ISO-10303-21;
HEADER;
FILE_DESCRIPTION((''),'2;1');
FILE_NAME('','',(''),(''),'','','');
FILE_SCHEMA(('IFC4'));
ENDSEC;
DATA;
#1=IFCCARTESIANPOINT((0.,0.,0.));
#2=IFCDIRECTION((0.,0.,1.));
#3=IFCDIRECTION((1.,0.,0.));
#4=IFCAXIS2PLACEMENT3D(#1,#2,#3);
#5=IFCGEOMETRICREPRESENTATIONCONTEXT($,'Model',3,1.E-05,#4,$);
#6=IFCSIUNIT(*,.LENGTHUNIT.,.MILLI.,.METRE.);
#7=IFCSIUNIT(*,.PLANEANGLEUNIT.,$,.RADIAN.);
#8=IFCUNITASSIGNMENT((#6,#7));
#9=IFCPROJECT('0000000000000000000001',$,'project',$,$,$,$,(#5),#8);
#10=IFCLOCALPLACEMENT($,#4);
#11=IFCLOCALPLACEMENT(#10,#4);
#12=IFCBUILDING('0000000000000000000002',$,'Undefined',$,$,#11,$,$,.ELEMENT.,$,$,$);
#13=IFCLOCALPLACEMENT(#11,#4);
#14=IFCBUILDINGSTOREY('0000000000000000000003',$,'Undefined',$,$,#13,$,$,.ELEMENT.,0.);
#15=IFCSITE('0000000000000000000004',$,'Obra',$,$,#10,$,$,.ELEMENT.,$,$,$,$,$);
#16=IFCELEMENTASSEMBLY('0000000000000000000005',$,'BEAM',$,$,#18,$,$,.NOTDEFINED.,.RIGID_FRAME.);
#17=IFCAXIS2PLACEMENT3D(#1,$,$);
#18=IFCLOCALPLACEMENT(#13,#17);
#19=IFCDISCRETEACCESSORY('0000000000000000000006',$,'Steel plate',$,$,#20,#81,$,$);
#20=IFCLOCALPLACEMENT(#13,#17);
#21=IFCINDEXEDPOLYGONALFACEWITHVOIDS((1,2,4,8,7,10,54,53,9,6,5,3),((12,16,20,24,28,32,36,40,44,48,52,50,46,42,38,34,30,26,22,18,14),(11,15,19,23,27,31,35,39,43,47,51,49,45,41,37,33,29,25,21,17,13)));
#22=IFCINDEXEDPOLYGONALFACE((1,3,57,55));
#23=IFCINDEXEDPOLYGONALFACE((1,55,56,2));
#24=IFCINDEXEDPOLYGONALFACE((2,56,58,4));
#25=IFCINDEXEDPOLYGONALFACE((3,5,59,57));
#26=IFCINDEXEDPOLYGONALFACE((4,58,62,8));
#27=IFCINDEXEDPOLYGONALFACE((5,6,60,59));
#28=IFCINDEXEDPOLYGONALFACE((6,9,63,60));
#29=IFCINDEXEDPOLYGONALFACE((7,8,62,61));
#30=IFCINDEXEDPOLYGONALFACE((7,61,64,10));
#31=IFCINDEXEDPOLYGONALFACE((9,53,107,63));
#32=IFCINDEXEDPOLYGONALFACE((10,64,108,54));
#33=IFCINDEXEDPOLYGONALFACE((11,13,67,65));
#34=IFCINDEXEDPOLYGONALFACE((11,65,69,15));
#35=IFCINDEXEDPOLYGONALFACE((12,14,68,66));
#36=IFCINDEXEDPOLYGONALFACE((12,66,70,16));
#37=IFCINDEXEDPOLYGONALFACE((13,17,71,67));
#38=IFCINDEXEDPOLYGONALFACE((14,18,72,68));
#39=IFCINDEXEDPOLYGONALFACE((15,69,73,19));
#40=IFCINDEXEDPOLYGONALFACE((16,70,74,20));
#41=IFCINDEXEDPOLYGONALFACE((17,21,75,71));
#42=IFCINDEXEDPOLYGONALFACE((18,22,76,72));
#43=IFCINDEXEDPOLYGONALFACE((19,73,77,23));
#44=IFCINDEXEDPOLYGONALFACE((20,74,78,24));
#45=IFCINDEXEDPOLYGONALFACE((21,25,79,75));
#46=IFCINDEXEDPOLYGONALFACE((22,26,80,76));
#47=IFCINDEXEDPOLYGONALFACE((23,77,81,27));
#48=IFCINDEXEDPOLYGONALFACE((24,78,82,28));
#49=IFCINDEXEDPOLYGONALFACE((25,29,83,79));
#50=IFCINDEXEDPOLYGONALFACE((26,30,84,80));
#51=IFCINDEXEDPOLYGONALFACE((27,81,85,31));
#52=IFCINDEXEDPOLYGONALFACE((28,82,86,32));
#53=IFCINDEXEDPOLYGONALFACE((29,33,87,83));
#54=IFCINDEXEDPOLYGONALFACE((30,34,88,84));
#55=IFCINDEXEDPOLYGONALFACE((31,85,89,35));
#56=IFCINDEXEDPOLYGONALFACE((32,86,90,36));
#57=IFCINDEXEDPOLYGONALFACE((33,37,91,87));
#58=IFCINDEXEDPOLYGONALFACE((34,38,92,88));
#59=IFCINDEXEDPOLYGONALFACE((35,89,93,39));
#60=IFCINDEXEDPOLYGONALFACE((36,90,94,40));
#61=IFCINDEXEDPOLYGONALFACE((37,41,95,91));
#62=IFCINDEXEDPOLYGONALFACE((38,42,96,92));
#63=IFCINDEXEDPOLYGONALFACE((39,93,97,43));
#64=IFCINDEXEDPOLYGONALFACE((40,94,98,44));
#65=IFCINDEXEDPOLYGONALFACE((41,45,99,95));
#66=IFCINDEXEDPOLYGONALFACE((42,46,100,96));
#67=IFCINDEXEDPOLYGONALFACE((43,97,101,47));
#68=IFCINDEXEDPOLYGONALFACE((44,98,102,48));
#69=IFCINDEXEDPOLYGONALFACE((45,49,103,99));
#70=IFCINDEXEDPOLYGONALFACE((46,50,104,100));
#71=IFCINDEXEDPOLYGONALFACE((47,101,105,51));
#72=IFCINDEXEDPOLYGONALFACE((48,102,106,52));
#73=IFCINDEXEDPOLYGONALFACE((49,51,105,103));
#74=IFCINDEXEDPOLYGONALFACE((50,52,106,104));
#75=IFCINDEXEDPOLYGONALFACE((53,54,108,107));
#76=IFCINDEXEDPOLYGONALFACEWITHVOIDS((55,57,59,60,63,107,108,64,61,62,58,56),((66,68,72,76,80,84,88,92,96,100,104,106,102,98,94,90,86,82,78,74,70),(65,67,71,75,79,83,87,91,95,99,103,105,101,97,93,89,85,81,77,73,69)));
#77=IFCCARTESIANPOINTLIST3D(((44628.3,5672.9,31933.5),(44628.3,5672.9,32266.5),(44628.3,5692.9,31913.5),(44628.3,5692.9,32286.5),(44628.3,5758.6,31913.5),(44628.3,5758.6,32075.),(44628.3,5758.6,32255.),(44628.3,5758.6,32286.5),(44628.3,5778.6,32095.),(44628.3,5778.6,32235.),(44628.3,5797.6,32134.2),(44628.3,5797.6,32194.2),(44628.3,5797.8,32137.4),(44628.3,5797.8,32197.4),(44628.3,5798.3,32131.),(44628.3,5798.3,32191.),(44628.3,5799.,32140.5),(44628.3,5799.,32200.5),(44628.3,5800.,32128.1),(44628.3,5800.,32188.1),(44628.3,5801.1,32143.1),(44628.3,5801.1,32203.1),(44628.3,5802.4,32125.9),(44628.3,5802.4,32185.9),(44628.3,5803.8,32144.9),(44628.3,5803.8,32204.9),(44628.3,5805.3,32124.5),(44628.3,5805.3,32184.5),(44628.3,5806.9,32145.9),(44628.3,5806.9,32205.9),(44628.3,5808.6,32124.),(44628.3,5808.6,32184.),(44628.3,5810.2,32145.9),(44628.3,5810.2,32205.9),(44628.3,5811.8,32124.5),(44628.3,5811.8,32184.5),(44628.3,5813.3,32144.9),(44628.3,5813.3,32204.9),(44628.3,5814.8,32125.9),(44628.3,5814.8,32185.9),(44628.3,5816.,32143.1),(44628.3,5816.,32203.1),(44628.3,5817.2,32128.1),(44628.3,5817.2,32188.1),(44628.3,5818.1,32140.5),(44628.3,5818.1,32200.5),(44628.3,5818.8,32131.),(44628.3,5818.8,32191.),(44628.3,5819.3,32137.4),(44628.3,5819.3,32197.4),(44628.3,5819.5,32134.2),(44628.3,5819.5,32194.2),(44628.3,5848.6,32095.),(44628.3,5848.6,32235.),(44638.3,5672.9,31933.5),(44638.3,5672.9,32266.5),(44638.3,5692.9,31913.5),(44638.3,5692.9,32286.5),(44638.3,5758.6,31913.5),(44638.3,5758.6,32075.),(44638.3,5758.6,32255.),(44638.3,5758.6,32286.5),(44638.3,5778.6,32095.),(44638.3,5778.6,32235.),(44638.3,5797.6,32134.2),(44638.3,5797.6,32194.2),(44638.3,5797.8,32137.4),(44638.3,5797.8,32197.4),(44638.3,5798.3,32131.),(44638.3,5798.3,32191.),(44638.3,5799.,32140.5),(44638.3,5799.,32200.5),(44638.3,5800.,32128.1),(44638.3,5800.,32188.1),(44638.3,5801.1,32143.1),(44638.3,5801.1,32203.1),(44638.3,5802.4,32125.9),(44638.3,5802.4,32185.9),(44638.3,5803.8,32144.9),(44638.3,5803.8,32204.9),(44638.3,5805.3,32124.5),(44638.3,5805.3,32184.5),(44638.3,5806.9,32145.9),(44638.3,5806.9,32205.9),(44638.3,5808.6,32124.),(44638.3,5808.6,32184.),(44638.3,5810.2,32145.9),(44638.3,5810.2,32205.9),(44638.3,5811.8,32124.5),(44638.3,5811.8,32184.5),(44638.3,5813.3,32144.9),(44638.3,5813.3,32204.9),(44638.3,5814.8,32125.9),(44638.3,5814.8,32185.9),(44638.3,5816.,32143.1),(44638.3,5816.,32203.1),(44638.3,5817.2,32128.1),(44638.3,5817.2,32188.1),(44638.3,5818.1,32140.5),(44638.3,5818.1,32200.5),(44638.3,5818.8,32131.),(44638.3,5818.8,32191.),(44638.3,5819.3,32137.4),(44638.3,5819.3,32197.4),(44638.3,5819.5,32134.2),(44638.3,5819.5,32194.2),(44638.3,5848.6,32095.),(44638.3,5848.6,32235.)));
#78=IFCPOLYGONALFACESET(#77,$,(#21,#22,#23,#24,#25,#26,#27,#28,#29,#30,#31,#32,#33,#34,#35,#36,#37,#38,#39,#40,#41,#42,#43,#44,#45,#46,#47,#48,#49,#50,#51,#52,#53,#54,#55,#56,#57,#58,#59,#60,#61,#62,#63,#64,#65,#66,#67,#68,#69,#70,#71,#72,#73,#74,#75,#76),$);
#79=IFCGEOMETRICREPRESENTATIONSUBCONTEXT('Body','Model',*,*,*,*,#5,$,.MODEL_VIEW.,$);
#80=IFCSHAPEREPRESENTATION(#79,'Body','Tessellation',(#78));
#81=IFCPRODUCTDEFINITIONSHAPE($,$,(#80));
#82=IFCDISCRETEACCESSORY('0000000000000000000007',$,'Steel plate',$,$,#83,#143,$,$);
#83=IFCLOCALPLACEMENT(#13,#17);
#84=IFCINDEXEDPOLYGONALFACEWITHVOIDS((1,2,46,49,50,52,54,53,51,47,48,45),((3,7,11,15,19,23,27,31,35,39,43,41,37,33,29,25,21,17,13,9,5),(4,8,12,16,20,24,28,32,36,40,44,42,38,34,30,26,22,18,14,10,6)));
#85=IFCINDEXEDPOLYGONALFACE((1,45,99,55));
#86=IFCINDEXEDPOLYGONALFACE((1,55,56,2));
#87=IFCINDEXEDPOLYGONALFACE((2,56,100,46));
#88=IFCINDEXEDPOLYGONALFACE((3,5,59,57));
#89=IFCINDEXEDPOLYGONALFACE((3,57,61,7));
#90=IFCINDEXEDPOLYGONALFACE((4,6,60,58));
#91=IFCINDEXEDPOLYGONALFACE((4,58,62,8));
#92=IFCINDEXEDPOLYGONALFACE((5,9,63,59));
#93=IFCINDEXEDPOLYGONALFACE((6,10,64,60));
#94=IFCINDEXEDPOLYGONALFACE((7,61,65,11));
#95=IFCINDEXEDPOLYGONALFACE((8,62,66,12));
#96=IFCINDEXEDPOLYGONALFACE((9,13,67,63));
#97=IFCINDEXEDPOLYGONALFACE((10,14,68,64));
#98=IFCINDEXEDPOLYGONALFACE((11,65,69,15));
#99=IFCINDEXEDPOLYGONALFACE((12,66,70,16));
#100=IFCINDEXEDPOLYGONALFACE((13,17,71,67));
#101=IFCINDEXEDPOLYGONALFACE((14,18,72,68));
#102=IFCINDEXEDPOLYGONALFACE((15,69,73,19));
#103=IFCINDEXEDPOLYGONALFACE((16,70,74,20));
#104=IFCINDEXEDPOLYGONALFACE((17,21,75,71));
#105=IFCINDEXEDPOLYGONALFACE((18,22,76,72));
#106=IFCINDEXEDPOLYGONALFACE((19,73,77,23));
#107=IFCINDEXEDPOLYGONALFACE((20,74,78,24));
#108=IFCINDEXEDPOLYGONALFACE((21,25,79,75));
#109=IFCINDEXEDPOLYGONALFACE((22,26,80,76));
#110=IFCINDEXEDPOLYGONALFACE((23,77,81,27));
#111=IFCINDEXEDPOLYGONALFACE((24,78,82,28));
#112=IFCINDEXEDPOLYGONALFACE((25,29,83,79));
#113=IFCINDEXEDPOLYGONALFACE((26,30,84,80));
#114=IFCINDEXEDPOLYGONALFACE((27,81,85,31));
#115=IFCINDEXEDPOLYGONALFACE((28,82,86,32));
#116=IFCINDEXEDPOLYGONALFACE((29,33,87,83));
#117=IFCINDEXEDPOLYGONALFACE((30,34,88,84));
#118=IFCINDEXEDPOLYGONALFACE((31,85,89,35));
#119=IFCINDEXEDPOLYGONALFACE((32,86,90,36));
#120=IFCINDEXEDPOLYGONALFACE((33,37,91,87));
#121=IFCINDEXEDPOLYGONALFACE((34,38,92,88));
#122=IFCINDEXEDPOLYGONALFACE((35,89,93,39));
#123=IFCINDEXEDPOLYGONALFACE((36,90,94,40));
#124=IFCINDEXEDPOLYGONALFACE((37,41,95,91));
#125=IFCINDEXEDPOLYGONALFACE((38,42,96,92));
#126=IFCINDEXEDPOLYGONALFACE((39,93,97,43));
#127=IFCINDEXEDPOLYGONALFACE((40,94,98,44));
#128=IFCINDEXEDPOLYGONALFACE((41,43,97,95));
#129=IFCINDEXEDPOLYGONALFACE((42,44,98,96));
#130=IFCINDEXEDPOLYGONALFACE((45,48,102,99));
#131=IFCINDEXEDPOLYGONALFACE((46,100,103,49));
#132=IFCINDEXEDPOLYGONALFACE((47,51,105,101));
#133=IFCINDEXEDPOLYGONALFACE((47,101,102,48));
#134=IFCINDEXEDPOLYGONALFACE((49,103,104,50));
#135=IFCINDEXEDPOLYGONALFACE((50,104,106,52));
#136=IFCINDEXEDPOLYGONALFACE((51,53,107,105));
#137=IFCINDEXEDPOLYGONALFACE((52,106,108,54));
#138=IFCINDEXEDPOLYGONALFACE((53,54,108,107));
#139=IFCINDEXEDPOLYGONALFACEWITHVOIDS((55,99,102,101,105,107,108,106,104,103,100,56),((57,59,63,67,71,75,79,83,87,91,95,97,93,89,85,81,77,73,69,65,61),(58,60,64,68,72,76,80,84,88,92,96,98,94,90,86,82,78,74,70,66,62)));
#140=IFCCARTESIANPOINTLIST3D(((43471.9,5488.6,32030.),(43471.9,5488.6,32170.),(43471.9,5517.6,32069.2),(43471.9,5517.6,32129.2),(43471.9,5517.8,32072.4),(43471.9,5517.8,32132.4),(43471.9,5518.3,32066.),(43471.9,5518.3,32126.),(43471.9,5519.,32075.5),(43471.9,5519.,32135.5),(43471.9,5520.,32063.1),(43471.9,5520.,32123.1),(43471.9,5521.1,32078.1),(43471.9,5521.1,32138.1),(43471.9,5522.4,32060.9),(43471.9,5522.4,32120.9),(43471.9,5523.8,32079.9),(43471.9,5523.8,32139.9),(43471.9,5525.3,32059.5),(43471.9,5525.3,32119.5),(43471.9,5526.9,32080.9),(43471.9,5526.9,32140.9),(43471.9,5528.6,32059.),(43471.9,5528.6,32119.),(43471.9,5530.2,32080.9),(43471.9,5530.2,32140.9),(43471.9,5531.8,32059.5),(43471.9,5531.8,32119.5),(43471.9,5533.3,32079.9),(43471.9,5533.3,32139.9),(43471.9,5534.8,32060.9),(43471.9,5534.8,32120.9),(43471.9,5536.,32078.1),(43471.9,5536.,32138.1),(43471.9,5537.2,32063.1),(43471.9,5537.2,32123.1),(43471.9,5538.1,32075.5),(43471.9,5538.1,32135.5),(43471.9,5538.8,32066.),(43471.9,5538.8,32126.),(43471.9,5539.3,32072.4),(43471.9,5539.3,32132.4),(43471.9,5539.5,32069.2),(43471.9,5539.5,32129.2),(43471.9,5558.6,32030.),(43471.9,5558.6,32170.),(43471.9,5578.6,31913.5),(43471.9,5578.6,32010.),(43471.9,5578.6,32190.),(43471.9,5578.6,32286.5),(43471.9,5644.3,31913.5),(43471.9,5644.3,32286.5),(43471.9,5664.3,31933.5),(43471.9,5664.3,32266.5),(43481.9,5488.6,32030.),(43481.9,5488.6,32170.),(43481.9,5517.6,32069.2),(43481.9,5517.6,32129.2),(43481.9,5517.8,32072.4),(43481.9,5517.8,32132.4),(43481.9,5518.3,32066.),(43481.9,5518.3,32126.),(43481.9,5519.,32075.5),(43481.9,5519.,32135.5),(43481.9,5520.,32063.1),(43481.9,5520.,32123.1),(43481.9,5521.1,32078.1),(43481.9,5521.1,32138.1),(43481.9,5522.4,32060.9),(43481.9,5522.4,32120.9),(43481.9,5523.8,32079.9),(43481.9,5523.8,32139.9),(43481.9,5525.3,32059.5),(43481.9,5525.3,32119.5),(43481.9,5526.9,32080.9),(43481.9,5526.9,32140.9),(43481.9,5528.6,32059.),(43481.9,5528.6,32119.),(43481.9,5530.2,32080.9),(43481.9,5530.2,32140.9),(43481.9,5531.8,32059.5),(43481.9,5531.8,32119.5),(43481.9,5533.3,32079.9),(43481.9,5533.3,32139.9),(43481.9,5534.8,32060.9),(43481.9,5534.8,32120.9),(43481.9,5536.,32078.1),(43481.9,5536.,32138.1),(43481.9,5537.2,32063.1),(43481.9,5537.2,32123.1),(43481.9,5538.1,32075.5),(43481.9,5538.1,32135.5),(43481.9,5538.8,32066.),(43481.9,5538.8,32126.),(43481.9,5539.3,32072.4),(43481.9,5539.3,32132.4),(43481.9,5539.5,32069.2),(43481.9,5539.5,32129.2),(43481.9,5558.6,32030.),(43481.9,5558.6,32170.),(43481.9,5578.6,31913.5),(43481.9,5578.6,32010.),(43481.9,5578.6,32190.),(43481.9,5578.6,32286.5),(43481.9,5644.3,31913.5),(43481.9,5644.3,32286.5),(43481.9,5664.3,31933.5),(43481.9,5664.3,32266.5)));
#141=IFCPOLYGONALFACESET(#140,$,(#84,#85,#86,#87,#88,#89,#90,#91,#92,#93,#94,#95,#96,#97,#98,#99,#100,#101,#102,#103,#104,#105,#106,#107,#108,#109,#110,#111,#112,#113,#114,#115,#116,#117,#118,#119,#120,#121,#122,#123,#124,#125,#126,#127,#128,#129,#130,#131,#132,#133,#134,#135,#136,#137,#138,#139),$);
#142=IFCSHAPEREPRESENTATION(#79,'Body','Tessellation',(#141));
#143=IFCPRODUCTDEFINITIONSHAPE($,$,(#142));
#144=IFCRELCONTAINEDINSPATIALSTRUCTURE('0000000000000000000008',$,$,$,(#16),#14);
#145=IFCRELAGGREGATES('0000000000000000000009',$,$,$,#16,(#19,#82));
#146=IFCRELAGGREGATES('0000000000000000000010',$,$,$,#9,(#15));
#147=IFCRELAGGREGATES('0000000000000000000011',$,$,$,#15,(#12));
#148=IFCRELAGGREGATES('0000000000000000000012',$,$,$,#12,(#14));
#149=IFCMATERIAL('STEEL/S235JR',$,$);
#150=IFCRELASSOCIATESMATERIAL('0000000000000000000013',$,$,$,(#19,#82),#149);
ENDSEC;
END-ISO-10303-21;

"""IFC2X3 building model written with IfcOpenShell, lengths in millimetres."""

from ifc_helpers import new_model, si_unit, frame, origin_with_axes, origin_2d_with_axis, place, context, subcontext, project, spatial, polyline, circle, outline, extrude, source, transform, mapped, material, element, aggregate, save


model = new_model("IFC2X3")

# Units and contexts
model_context = context("Model", 3, precision=1e-05, world=origin_with_axes())
body_context = subcontext(model_context, "Body", "Model", "MODEL_VIEW")
ifc_project = project(units=[si_unit("LENGTHUNIT", "METRE", prefix="MILLI"), si_unit("PLANEANGLEUNIT", "RADIAN")], contexts=[model_context])

# Site, building, storey
site_placement = place(None, origin_with_axes())
site = spatial("IfcSite", under=ifc_project, at=site_placement, Name="Obra", CompositionType="ELEMENT")
building_placement = place(site_placement, origin_with_axes())
building = spatial("IfcBuilding", under=site, at=building_placement, Name="Undefined", CompositionType="ELEMENT")
storey_placement = place(building_placement, origin_with_axes())
storey = spatial("IfcBuildingStorey", under=building, at=storey_placement, Name="Undefined", CompositionType="ELEMENT", Elevation=0.0)

# Element assembly
assembly_1_placement = place(storey_placement, origin_with_axes())
assembly_1 = element("IfcElementAssembly", 1, at=assembly_1_placement, inside=storey, Name="BEAM", AssemblyPlace="NOTDEFINED", PredefinedType="RIGID_FRAME")
ifc_material_1 = material(Name="STEEL/S235JR")

# Discrete accessories, openings
shared_shape_1 = source(origin_with_axes(), body_context, "Body", "SweptSolid", [
    extrude(circle(Radius=11.0, at=origin_2d_with_axis()), frame((0.0, -13.4, 0.0), z_axis=(0.0, 1.0, 0.0), x_axis=(1.0, 0.0, 0.0)), (0.0, 0.0, 1.0), 10.2),
])
discrete_accessory_1_placement = place(assembly_1_placement, frame((44633.3, 5672.9, 31933.5), z_axis=(1.0, 0.0, 0.0), x_axis=(0.0, 0.707107, -0.707107)))
discrete_accessory_1 = element("IfcDiscreteAccessory", 2, at=discrete_accessory_1_placement, material=ifc_material_1, Name="Steel plate", context=body_context, shape_type="SweptSolid", body=[
    extrude(outline(polyline([(0.0, 0.0), (28.3, 0.0), (74.7, 46.5), (-39.5, 160.7), (-39.5, 188.9), (10.0, 238.4), (-89.0, 337.4), (-138.5, 287.9), (-166.7, 287.9), (-189.0, 310.2), (-235.5, 263.8), (-235.5, 235.5), (0.0, 0.0)])), frame((0.0, 0.0, -5.0), z_axis=(0.0, 0.0, 1.0), x_axis=(1.0, 0.0, 0.0)), (0.0, 0.0, 1.0), 10.0),
])
opening_1_placement = place(assembly_1_placement, frame((44625.0, 5768.6, 32235.0), z_axis=(0.0, 1.0, 0.0), x_axis=(0.0, 0.0, -1.0)))
element("IfcOpeningElement", 3, at=opening_1_placement, cuts=discrete_accessory_1, ObjectType="Opening", context=body_context, shape_type="MappedRepresentation", body=[
    mapped(shared_shape_1, transform((40.0, 0.0, 40.0))),
    mapped(shared_shape_1, transform((100.0, 0.0, 40.0))),
])
discrete_accessory_2_placement = place(assembly_1_placement, frame((43476.9, 5664.3, 31933.5), z_axis=(-1.0, 0.0, 0.0), x_axis=(0.0, -0.707107, -0.707107)))
discrete_accessory_2 = element("IfcDiscreteAccessory", 4, at=discrete_accessory_2_placement, material=ifc_material_1, Name="Steel plate", context=body_context, shape_type="SweptSolid", body=[
    extrude(outline(polyline([(0.0, 0.0), (28.3, 0.0), (74.7, 46.5), (6.5, 114.7), (6.5, 143.0), (56.0, 192.5), (-43.0, 291.5), (-92.5, 242.0), (-120.8, 242.0), (-189.0, 310.2), (-235.5, 263.8), (-235.5, 235.5), (0.0, 0.0)])), frame((0.0, 0.0, -5.0), z_axis=(0.0, 0.0, 1.0), x_axis=(1.0, 0.0, 0.0)), (0.0, 0.0, 1.0), 10.0),
])
shared_shape_2 = source(origin_with_axes(), body_context, "Body", "SweptSolid", [
    extrude(circle(Radius=11.0, at=origin_2d_with_axis()), frame((0.0, -14.4, 0.0), z_axis=(0.0, 1.0, 0.0), x_axis=(1.0, 0.0, 0.0)), (0.0, 0.0, 1.0), 10.2),
])
opening_2_placement = place(assembly_1_placement, frame((43486.2, 5568.6, 32170.0), z_axis=(0.0, -1.0, 0.0), x_axis=(0.0, 0.0, -1.0)))
element("IfcOpeningElement", 5, at=opening_2_placement, cuts=discrete_accessory_2, ObjectType="Opening", context=body_context, shape_type="MappedRepresentation", body=[
    mapped(shared_shape_2, transform((40.0, 0.0, 40.0))),
    mapped(shared_shape_2, transform((100.0, 0.0, 40.0))),
])
aggregate(assembly_1, [discrete_accessory_1, discrete_accessory_2])

save(model, "model.ifc")
